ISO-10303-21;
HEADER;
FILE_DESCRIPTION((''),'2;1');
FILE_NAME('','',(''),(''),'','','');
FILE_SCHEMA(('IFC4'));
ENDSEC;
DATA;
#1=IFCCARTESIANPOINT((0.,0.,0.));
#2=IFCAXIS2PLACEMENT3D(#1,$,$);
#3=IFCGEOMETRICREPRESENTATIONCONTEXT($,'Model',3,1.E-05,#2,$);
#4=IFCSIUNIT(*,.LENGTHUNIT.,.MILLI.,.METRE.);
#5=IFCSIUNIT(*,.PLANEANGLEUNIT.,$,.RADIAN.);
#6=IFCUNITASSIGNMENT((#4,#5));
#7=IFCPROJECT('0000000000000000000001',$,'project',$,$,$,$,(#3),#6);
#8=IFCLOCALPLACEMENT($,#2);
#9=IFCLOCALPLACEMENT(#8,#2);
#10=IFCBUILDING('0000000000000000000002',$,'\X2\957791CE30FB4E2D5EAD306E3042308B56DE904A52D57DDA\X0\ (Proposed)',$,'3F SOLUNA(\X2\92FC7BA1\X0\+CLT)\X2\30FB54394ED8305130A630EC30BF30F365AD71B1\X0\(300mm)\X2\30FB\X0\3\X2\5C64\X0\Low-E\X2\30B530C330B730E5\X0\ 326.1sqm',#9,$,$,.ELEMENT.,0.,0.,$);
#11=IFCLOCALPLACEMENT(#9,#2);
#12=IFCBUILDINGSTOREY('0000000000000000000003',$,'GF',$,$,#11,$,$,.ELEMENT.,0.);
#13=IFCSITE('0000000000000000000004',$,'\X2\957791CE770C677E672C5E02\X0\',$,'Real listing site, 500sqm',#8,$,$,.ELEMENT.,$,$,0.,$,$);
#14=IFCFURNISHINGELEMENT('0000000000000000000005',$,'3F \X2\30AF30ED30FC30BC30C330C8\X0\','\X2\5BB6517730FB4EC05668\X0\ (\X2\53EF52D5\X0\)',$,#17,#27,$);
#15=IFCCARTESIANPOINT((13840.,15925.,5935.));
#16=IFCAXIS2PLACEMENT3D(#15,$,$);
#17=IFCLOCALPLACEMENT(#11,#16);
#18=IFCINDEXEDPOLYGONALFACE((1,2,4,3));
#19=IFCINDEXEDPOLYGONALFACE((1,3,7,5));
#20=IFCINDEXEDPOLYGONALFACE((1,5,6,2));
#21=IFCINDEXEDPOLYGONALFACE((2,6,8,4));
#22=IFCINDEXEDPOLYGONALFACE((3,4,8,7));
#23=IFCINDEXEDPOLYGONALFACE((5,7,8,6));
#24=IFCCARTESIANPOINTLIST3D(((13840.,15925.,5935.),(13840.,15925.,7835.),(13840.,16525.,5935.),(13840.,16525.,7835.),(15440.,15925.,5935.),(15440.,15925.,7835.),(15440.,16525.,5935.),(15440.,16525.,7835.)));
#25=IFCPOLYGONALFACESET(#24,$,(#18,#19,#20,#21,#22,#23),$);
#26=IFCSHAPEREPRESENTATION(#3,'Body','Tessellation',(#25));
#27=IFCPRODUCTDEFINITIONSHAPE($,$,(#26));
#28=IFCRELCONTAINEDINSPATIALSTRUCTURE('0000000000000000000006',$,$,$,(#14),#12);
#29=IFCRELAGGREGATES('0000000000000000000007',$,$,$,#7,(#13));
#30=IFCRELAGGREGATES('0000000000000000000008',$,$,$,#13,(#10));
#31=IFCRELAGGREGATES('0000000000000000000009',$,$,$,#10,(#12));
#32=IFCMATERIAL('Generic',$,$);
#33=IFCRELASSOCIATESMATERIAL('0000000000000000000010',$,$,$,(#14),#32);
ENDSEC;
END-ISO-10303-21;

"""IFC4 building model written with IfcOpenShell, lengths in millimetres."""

from ifc_helpers import new_model, si_unit, frame, frame_2d, origin, place, context, project, spatial, rectangle, extrude, material, element, save


model = new_model("IFC4")

# Units and contexts
model_context = context("Model", 3, precision=1e-05, world=origin())
ifc_project = project(units=[si_unit("LENGTHUNIT", "METRE", prefix="MILLI"), si_unit("PLANEANGLEUNIT", "RADIAN")], contexts=[model_context])

# Site, building, storey
site_placement = place(None, origin())
site = spatial("IfcSite", under=ifc_project, at=site_placement, Name="長野県松本市", ObjectType="Real listing site, 500sqm", CompositionType="ELEMENT", RefElevation=0.0)
building_placement = place(site_placement, origin())
building = spatial("IfcBuilding", under=site, at=building_placement, Name="長野・中庭のある回遊動線 (Proposed)", ObjectType="3F SOLUNA(鋼管+CLT)・吹付けウレタン断熱(300mm)・3層Low-Eサッシュ 326.1sqm", CompositionType="ELEMENT", ElevationOfRefHeight=0.0, ElevationOfTerrain=0.0)
storey_placement = place(building_placement, origin())
storey = spatial("IfcBuildingStorey", under=building, at=storey_placement, Name="GF", CompositionType="ELEMENT", Elevation=0.0)

# Shared definitions
ifc_material_1 = material(Name="Generic")

# Furnishing element
furnishing_1_placement = place(storey_placement, frame((13840.0, 15925.0, 5935.0)))
element("IfcFurnishingElement", 1, at=furnishing_1_placement, inside=storey, material=ifc_material_1, Name="3F クローゼット", Description="家具・什器 (可動)", context=model_context, shape_type="SweptSolid", body=[
    extrude(rectangle(XDim=1600.0, YDim=600.0, at=frame_2d((800.0, 300.0))), frame((13840.0, 15925.0, 5935.0)), (0.0, 0.0, 1.0), 1900.0),
])

save(model, "model.ifc")
